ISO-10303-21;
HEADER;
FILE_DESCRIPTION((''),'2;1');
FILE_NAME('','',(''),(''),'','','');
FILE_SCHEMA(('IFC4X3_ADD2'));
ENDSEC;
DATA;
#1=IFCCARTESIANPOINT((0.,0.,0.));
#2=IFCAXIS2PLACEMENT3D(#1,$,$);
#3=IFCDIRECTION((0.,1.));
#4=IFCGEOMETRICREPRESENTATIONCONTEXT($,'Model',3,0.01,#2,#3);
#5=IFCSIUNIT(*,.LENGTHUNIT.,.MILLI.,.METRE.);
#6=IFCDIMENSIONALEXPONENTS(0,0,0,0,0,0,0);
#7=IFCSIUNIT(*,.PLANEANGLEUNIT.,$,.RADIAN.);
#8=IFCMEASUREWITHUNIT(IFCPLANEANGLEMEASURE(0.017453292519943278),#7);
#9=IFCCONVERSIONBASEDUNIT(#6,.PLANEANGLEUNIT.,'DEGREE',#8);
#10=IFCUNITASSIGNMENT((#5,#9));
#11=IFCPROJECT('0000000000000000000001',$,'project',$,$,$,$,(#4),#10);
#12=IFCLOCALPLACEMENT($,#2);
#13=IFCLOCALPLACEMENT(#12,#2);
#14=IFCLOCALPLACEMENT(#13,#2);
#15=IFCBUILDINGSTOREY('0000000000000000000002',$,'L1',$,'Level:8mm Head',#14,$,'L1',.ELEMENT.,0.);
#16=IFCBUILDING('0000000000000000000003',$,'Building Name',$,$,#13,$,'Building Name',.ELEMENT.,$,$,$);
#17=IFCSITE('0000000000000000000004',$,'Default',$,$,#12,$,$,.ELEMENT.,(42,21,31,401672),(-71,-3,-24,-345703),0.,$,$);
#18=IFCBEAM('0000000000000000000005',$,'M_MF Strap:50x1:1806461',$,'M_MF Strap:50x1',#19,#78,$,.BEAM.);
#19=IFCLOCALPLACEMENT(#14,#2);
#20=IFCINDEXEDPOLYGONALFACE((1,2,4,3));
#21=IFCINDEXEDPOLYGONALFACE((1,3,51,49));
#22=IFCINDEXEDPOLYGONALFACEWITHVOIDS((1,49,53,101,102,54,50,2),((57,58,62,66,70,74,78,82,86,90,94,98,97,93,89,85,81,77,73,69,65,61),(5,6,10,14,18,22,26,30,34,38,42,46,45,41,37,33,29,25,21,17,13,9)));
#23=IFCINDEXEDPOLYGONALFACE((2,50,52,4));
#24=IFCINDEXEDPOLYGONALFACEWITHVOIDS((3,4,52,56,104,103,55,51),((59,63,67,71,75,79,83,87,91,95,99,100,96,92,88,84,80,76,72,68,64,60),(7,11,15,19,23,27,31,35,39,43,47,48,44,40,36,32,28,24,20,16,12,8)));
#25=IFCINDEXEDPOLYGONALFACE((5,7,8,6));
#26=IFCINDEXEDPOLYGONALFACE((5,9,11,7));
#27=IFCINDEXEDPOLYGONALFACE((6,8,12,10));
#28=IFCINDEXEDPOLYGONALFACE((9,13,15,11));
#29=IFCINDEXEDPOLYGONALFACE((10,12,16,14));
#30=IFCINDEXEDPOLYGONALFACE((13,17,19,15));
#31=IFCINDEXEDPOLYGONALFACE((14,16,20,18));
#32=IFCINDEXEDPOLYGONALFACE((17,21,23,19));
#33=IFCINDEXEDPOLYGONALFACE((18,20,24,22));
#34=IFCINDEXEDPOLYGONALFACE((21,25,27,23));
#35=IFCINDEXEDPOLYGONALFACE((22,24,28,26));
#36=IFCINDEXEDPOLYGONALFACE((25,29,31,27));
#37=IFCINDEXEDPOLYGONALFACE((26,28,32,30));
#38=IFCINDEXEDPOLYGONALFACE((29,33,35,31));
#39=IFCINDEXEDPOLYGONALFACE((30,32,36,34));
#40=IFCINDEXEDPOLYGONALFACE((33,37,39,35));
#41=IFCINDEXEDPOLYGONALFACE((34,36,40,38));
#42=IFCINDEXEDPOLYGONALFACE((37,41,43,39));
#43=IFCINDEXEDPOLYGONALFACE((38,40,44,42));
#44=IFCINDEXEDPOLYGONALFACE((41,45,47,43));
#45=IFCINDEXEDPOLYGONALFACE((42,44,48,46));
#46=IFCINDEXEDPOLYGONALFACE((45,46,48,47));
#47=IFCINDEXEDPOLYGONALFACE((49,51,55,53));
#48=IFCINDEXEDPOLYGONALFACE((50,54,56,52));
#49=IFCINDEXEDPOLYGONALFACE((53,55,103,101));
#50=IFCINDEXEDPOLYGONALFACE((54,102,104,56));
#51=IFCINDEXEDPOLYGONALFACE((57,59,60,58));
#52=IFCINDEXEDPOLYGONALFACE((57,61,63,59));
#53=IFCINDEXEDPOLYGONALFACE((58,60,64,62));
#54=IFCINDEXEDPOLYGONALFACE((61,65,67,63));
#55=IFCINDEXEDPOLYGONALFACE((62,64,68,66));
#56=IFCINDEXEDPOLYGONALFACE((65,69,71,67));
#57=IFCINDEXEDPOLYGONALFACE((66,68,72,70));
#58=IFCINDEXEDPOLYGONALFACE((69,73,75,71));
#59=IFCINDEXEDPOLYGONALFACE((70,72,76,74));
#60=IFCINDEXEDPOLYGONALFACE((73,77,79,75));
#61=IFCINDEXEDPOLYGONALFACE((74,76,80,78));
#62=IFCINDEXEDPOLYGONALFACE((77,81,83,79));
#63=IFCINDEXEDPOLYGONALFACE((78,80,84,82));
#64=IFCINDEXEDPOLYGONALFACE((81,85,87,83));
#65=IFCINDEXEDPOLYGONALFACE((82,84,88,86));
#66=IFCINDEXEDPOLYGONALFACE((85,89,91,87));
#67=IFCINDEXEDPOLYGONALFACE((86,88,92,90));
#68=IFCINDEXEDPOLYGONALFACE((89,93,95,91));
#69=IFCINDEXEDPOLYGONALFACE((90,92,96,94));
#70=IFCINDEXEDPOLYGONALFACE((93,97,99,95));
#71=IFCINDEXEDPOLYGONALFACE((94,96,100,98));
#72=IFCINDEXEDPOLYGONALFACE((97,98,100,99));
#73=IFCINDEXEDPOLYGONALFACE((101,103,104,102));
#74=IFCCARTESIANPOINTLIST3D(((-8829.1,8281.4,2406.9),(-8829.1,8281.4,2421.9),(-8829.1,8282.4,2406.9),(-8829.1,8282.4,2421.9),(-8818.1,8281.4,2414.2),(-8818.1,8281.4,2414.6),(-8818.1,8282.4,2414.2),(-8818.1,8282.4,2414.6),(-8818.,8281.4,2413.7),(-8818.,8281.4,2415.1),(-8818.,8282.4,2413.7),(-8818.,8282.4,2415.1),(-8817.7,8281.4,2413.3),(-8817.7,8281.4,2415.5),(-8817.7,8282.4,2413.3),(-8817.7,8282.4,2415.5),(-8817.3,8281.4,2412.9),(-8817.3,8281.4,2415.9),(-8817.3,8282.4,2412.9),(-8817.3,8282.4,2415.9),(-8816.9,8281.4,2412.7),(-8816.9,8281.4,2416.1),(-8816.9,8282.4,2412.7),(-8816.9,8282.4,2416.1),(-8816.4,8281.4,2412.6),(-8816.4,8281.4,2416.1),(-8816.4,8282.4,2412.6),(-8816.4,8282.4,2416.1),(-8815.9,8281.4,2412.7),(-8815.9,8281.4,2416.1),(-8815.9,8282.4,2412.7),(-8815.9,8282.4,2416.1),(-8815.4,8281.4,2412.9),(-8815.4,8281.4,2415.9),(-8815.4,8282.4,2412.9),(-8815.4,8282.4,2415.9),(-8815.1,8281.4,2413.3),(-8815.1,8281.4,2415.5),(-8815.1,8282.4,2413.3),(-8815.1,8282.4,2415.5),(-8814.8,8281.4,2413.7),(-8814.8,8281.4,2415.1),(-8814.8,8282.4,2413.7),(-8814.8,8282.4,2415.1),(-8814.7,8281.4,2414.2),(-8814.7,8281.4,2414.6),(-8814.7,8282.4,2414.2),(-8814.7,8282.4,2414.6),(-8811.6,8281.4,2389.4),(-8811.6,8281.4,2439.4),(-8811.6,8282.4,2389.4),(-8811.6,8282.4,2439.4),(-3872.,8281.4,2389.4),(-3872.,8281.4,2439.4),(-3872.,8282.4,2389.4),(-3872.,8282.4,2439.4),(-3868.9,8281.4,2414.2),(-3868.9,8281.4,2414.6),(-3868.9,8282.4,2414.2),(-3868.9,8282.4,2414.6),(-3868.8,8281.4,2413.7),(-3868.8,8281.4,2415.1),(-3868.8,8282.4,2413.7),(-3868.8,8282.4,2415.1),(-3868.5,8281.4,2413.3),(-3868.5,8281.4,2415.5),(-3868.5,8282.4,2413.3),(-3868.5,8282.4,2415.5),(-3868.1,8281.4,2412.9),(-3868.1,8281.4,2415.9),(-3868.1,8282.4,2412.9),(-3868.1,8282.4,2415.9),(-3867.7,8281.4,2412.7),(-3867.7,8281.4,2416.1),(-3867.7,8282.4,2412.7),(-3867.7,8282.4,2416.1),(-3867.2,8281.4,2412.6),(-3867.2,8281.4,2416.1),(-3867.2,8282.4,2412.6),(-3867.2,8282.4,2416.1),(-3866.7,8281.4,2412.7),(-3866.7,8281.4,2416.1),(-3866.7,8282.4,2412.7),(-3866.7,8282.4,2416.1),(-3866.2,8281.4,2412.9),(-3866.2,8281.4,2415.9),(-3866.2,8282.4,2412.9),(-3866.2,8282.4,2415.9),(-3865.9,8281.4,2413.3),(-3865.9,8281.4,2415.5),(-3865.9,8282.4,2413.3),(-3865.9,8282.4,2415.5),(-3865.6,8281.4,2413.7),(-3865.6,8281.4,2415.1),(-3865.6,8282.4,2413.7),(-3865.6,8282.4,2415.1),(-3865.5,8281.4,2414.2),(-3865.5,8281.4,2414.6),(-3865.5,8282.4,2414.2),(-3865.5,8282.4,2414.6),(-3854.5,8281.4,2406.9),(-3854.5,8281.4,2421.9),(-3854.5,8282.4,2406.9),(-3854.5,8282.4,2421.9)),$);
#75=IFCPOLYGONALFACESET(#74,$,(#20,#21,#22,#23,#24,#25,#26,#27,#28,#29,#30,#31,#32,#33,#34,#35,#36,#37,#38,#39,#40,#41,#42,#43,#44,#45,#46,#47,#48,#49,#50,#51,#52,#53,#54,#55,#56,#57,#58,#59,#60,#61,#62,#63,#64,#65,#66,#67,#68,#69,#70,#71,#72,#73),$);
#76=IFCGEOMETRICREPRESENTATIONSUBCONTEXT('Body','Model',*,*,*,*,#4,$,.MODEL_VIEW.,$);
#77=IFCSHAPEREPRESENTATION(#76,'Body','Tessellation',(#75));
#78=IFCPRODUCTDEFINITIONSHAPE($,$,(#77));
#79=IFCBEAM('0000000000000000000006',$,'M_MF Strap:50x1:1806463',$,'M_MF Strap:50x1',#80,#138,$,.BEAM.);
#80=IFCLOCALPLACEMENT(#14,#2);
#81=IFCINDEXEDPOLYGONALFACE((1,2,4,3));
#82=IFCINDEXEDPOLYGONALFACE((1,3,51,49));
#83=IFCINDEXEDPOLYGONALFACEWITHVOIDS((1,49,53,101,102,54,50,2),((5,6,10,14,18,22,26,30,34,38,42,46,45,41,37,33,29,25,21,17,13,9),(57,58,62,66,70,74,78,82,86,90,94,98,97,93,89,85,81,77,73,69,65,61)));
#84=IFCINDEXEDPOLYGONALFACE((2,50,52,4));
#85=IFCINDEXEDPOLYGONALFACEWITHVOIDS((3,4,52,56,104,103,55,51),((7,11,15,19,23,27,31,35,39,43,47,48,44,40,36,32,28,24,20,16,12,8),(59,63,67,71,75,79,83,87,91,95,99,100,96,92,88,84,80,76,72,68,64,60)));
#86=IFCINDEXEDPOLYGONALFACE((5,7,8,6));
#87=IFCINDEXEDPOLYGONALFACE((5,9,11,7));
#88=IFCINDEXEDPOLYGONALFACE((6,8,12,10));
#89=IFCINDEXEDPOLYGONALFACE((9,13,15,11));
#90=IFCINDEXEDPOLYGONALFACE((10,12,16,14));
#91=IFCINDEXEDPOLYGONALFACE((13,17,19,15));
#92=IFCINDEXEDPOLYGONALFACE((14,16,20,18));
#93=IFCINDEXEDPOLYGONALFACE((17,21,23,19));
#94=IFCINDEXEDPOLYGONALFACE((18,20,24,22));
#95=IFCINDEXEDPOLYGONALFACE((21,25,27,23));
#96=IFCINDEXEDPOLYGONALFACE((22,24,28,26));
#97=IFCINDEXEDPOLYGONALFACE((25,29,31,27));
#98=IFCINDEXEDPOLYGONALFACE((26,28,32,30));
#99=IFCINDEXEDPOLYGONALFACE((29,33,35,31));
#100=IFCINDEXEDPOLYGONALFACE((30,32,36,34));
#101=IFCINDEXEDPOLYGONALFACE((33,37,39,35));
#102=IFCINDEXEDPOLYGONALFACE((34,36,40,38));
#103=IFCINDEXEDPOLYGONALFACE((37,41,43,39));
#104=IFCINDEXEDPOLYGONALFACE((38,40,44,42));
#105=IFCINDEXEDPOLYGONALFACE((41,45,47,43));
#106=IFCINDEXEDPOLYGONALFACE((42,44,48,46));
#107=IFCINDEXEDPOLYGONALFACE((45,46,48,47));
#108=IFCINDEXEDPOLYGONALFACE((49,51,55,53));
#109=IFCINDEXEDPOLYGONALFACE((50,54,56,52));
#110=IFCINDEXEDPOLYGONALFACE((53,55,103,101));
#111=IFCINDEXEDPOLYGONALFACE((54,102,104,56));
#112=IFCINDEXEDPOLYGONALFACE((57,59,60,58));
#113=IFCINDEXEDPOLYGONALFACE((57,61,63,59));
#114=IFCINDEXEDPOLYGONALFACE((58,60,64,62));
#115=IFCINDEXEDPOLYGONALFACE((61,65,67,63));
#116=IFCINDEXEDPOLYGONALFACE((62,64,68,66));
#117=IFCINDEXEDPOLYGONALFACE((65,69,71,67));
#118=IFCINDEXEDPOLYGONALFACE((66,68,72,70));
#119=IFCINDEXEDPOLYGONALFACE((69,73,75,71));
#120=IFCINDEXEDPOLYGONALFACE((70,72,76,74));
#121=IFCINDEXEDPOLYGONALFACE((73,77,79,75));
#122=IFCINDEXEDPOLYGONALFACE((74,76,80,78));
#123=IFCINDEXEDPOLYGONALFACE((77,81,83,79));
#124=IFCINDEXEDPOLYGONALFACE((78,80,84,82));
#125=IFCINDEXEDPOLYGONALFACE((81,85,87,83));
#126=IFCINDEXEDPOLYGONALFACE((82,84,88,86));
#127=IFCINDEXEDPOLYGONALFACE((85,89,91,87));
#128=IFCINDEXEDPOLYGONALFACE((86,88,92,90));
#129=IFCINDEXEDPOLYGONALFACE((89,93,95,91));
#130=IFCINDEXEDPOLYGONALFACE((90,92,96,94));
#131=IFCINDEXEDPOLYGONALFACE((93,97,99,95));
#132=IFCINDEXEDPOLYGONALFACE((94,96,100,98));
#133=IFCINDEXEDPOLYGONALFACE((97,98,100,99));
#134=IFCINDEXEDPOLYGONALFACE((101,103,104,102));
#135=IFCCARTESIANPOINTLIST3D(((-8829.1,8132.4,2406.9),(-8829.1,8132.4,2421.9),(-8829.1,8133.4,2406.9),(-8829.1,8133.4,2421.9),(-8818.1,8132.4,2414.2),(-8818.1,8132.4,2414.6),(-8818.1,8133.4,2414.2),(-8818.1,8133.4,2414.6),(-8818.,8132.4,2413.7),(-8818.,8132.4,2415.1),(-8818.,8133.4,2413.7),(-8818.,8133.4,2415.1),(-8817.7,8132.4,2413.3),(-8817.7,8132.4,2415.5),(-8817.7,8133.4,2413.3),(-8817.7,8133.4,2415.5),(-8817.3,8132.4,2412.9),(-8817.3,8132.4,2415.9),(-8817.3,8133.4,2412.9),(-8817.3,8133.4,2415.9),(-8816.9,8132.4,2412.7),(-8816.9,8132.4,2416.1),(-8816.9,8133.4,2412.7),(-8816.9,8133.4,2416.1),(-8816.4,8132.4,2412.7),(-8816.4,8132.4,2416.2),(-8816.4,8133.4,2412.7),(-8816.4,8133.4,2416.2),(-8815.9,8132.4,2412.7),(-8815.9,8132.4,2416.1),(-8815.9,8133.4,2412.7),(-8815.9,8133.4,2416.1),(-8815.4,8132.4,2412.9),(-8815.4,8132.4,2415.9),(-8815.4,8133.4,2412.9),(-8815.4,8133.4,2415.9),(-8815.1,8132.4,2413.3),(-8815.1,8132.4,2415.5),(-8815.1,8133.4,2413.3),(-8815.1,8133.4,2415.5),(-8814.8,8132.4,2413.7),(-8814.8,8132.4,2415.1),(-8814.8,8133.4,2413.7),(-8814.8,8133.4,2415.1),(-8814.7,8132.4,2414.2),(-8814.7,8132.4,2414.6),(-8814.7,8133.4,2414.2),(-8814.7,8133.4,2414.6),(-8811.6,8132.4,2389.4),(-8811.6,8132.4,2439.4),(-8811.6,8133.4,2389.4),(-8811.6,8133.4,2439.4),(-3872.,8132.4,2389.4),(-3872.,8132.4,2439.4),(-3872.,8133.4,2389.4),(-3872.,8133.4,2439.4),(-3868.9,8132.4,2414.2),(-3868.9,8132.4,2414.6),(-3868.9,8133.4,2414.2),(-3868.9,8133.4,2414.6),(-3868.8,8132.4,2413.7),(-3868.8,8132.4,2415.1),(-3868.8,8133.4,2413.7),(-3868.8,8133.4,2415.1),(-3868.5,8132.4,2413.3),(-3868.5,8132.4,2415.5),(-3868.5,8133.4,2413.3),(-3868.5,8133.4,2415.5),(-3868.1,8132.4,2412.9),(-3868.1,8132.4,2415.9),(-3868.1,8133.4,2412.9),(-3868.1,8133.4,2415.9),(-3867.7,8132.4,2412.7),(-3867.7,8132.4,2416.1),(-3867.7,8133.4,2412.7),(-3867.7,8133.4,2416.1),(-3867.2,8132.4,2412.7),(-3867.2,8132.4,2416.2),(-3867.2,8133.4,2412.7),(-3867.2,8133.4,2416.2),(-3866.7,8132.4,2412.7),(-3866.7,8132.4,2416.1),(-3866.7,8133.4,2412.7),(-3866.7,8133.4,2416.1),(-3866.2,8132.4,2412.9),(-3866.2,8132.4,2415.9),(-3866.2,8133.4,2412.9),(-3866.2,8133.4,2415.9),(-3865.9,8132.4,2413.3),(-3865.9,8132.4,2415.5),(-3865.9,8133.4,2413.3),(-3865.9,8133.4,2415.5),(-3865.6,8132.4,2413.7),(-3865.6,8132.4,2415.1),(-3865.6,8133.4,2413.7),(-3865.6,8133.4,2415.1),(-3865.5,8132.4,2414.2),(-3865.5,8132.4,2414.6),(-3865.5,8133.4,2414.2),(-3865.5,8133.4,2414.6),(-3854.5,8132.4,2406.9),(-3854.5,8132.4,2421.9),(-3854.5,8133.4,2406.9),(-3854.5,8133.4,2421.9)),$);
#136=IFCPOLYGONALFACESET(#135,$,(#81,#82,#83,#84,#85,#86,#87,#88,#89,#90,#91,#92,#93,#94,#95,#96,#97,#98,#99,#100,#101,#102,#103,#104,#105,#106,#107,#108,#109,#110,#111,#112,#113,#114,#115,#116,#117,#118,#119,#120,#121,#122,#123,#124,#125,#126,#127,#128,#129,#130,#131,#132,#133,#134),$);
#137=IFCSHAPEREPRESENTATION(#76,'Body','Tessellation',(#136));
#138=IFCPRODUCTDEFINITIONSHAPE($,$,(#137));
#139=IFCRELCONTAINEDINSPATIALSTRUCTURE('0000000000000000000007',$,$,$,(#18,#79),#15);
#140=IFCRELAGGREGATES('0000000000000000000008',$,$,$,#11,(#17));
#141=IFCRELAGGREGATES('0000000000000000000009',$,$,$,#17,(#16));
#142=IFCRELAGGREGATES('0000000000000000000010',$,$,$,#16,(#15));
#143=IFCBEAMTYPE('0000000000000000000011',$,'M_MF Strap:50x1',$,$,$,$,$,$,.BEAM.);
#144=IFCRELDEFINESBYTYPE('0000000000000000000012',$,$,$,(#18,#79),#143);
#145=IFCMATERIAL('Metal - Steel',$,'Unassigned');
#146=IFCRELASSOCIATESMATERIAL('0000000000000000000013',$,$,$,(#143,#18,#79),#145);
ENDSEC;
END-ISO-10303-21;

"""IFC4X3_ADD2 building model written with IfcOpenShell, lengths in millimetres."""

from ifc_helpers import new_model, entity, si_unit, converted_unit, direction, frame, frame_2d, origin, place, context, subcontext, project, spatial, polyline, circle_curve, parameter, trimmed, segment, composite_curve, outline, extrude, source, transform, mapped, material, material_profile, profile_set, profile_usage, type_object, type_shapes, element, save


model = new_model("IFC4X3_ADD2")

# Units and contexts
model_context = context("Model", 3, precision=0.01, world=origin(), true_north=direction((0.0, 1.0)))
body_context = subcontext(model_context, "Body", "Model", "MODEL_VIEW")
ifc_project = project(units=[si_unit("LENGTHUNIT", "METRE", prefix="MILLI"), converted_unit("PLANEANGLEUNIT", "DEGREE", entity("IfcPlaneAngleMeasure", 0.017453292519943278), si_unit("PLANEANGLEUNIT", "RADIAN"), dimensions=[0, 0, 0, 0, 0, 0, 0])], contexts=[model_context])

# Site, building, storey
site_placement = place(None, origin())
site = spatial("IfcSite", under=ifc_project, at=site_placement, Name="Default", CompositionType="ELEMENT", RefLatitude=(42, 21, 31, 401672), RefLongitude=(-71, -3, -24, -345703), RefElevation=0.0)
building_placement = place(site_placement, origin())
building = spatial("IfcBuilding", under=site, at=building_placement, Name="Building Name", LongName="Building Name", CompositionType="ELEMENT")
storey_placement = place(building_placement, origin())
storey = spatial("IfcBuildingStorey", under=building, at=storey_placement, Name="L1", ObjectType="Level:8mm Head", LongName="L1", CompositionType="ELEMENT", Elevation=0.0)

# Beams
ifc_material_1 = material(Name="Metal - Steel", Category="Unassigned")
ifc_material_profile = material_profile(ifc_material_1, outline(polyline([(-1753.5, -1764.1), (-1728.7, -1764.1), (1764.1, 1728.7), (1764.1, 1753.5), (1753.5, 1764.1), (1728.7, 1764.1), (-1764.1, -1728.7), (-1764.1, -1753.5), (-1753.5, -1764.1)]), holes=[composite_curve([segment(trimmed(circle_curve(frame_2d((-1749.8, -1749.8), x_axis=(0.707107, -0.707107)), 1.8), [parameter(180.0)], [parameter(0.0)], True, "PARAMETER"), False, "CONTINUOUS"), segment(trimmed(circle_curve(frame_2d((-1749.8, -1749.8), x_axis=(0.707107, -0.707107)), 1.8), [parameter(0.0)], [parameter(180.0)], True, "PARAMETER"), False, "CONTINUOUS")], self_intersect=False), composite_curve([segment(trimmed(circle_curve(frame_2d((1749.8, 1749.8), x_axis=(0.707107, -0.707107)), 1.8), [parameter(180.0)], [parameter(360.0)], True, "PARAMETER"), False, "CONTINUOUS"), segment(trimmed(circle_curve(frame_2d((1749.8, 1749.8), x_axis=(0.707107, -0.707107)), 1.8), [parameter(360.0)], [parameter(180.0)], True, "PARAMETER"), False, "CONTINUOUS")], self_intersect=False)]), Name="50x1")
ifc_profile_set = profile_set([ifc_material_profile], Name="50x1")
ifc_profile_usage = profile_usage(ifc_profile_set, cardinal=5)
beam_type = type_object("IfcBeamType", Name="M_MF Strap:50x1", PredefinedType="BEAM", material=ifc_profile_set)
shared_shape_1 = source(origin(), body_context, "Body", "SweptSolid", [
    extrude(outline(polyline([(-1753.5, -1764.1), (-1728.7, -1764.1), (1764.1, 1728.7), (1764.1, 1753.5), (1753.5, 1764.1), (1728.7, 1764.1), (-1764.1, -1728.7), (-1764.1, -1753.5), (-1753.5, -1764.1)]), holes=[composite_curve([segment(trimmed(circle_curve(frame_2d((-1749.8, -1749.8), x_axis=(0.707107, -0.707107)), 1.8), [parameter(180.0)], [parameter(0.0)], True, "PARAMETER"), False, "CONTINUOUS"), segment(trimmed(circle_curve(frame_2d((-1749.8, -1749.8), x_axis=(0.707107, -0.707107)), 1.8), [parameter(0.0)], [parameter(180.0)], True, "PARAMETER"), False, "CONTINUOUS")], self_intersect=False), composite_curve([segment(trimmed(circle_curve(frame_2d((1749.8, 1749.8), x_axis=(0.707107, -0.707107)), 1.8), [parameter(180.0)], [parameter(360.0)], True, "PARAMETER"), False, "CONTINUOUS"), segment(trimmed(circle_curve(frame_2d((1749.8, 1749.8), x_axis=(0.707107, -0.707107)), 1.8), [parameter(360.0)], [parameter(180.0)], True, "PARAMETER"), False, "CONTINUOUS")], self_intersect=False)]), frame((0.0, -0.5, 0.0), z_axis=(0.0, 1.0, 0.0), x_axis=(0.707107, 0.0, 0.707107)), (0.0, 0.0, 1.0), 1.0),
])
type_shapes(beam_type, [shared_shape_1])
for number, where, z_axis, x_axis, name in (
    (1, (-6341.8, 8281.9, 2414.4), (0.0, 0.0, -1.0), (-1.0, 0.0, 0.0), "M_MF Strap:50x1:1806461"),
    (2, (-6341.8, 8132.9, 2414.4), (0.0, 0.0, 1.0), (-1.0, 0.0, 0.0), "M_MF Strap:50x1:1806463"),
):
    element("IfcBeam", number, at=place(storey_placement, frame(where, z_axis=z_axis, x_axis=x_axis)), inside=storey, type_object=beam_type, material=ifc_profile_usage, Name=name, ObjectType="M_MF Strap:50x1", PredefinedType="BEAM", context=body_context, shape_type="MappedRepresentation", body=[
        mapped(shared_shape_1, transform((0.0, 0.0, 0.0), scale=1.0)),
    ])

save(model, "model.ifc")
